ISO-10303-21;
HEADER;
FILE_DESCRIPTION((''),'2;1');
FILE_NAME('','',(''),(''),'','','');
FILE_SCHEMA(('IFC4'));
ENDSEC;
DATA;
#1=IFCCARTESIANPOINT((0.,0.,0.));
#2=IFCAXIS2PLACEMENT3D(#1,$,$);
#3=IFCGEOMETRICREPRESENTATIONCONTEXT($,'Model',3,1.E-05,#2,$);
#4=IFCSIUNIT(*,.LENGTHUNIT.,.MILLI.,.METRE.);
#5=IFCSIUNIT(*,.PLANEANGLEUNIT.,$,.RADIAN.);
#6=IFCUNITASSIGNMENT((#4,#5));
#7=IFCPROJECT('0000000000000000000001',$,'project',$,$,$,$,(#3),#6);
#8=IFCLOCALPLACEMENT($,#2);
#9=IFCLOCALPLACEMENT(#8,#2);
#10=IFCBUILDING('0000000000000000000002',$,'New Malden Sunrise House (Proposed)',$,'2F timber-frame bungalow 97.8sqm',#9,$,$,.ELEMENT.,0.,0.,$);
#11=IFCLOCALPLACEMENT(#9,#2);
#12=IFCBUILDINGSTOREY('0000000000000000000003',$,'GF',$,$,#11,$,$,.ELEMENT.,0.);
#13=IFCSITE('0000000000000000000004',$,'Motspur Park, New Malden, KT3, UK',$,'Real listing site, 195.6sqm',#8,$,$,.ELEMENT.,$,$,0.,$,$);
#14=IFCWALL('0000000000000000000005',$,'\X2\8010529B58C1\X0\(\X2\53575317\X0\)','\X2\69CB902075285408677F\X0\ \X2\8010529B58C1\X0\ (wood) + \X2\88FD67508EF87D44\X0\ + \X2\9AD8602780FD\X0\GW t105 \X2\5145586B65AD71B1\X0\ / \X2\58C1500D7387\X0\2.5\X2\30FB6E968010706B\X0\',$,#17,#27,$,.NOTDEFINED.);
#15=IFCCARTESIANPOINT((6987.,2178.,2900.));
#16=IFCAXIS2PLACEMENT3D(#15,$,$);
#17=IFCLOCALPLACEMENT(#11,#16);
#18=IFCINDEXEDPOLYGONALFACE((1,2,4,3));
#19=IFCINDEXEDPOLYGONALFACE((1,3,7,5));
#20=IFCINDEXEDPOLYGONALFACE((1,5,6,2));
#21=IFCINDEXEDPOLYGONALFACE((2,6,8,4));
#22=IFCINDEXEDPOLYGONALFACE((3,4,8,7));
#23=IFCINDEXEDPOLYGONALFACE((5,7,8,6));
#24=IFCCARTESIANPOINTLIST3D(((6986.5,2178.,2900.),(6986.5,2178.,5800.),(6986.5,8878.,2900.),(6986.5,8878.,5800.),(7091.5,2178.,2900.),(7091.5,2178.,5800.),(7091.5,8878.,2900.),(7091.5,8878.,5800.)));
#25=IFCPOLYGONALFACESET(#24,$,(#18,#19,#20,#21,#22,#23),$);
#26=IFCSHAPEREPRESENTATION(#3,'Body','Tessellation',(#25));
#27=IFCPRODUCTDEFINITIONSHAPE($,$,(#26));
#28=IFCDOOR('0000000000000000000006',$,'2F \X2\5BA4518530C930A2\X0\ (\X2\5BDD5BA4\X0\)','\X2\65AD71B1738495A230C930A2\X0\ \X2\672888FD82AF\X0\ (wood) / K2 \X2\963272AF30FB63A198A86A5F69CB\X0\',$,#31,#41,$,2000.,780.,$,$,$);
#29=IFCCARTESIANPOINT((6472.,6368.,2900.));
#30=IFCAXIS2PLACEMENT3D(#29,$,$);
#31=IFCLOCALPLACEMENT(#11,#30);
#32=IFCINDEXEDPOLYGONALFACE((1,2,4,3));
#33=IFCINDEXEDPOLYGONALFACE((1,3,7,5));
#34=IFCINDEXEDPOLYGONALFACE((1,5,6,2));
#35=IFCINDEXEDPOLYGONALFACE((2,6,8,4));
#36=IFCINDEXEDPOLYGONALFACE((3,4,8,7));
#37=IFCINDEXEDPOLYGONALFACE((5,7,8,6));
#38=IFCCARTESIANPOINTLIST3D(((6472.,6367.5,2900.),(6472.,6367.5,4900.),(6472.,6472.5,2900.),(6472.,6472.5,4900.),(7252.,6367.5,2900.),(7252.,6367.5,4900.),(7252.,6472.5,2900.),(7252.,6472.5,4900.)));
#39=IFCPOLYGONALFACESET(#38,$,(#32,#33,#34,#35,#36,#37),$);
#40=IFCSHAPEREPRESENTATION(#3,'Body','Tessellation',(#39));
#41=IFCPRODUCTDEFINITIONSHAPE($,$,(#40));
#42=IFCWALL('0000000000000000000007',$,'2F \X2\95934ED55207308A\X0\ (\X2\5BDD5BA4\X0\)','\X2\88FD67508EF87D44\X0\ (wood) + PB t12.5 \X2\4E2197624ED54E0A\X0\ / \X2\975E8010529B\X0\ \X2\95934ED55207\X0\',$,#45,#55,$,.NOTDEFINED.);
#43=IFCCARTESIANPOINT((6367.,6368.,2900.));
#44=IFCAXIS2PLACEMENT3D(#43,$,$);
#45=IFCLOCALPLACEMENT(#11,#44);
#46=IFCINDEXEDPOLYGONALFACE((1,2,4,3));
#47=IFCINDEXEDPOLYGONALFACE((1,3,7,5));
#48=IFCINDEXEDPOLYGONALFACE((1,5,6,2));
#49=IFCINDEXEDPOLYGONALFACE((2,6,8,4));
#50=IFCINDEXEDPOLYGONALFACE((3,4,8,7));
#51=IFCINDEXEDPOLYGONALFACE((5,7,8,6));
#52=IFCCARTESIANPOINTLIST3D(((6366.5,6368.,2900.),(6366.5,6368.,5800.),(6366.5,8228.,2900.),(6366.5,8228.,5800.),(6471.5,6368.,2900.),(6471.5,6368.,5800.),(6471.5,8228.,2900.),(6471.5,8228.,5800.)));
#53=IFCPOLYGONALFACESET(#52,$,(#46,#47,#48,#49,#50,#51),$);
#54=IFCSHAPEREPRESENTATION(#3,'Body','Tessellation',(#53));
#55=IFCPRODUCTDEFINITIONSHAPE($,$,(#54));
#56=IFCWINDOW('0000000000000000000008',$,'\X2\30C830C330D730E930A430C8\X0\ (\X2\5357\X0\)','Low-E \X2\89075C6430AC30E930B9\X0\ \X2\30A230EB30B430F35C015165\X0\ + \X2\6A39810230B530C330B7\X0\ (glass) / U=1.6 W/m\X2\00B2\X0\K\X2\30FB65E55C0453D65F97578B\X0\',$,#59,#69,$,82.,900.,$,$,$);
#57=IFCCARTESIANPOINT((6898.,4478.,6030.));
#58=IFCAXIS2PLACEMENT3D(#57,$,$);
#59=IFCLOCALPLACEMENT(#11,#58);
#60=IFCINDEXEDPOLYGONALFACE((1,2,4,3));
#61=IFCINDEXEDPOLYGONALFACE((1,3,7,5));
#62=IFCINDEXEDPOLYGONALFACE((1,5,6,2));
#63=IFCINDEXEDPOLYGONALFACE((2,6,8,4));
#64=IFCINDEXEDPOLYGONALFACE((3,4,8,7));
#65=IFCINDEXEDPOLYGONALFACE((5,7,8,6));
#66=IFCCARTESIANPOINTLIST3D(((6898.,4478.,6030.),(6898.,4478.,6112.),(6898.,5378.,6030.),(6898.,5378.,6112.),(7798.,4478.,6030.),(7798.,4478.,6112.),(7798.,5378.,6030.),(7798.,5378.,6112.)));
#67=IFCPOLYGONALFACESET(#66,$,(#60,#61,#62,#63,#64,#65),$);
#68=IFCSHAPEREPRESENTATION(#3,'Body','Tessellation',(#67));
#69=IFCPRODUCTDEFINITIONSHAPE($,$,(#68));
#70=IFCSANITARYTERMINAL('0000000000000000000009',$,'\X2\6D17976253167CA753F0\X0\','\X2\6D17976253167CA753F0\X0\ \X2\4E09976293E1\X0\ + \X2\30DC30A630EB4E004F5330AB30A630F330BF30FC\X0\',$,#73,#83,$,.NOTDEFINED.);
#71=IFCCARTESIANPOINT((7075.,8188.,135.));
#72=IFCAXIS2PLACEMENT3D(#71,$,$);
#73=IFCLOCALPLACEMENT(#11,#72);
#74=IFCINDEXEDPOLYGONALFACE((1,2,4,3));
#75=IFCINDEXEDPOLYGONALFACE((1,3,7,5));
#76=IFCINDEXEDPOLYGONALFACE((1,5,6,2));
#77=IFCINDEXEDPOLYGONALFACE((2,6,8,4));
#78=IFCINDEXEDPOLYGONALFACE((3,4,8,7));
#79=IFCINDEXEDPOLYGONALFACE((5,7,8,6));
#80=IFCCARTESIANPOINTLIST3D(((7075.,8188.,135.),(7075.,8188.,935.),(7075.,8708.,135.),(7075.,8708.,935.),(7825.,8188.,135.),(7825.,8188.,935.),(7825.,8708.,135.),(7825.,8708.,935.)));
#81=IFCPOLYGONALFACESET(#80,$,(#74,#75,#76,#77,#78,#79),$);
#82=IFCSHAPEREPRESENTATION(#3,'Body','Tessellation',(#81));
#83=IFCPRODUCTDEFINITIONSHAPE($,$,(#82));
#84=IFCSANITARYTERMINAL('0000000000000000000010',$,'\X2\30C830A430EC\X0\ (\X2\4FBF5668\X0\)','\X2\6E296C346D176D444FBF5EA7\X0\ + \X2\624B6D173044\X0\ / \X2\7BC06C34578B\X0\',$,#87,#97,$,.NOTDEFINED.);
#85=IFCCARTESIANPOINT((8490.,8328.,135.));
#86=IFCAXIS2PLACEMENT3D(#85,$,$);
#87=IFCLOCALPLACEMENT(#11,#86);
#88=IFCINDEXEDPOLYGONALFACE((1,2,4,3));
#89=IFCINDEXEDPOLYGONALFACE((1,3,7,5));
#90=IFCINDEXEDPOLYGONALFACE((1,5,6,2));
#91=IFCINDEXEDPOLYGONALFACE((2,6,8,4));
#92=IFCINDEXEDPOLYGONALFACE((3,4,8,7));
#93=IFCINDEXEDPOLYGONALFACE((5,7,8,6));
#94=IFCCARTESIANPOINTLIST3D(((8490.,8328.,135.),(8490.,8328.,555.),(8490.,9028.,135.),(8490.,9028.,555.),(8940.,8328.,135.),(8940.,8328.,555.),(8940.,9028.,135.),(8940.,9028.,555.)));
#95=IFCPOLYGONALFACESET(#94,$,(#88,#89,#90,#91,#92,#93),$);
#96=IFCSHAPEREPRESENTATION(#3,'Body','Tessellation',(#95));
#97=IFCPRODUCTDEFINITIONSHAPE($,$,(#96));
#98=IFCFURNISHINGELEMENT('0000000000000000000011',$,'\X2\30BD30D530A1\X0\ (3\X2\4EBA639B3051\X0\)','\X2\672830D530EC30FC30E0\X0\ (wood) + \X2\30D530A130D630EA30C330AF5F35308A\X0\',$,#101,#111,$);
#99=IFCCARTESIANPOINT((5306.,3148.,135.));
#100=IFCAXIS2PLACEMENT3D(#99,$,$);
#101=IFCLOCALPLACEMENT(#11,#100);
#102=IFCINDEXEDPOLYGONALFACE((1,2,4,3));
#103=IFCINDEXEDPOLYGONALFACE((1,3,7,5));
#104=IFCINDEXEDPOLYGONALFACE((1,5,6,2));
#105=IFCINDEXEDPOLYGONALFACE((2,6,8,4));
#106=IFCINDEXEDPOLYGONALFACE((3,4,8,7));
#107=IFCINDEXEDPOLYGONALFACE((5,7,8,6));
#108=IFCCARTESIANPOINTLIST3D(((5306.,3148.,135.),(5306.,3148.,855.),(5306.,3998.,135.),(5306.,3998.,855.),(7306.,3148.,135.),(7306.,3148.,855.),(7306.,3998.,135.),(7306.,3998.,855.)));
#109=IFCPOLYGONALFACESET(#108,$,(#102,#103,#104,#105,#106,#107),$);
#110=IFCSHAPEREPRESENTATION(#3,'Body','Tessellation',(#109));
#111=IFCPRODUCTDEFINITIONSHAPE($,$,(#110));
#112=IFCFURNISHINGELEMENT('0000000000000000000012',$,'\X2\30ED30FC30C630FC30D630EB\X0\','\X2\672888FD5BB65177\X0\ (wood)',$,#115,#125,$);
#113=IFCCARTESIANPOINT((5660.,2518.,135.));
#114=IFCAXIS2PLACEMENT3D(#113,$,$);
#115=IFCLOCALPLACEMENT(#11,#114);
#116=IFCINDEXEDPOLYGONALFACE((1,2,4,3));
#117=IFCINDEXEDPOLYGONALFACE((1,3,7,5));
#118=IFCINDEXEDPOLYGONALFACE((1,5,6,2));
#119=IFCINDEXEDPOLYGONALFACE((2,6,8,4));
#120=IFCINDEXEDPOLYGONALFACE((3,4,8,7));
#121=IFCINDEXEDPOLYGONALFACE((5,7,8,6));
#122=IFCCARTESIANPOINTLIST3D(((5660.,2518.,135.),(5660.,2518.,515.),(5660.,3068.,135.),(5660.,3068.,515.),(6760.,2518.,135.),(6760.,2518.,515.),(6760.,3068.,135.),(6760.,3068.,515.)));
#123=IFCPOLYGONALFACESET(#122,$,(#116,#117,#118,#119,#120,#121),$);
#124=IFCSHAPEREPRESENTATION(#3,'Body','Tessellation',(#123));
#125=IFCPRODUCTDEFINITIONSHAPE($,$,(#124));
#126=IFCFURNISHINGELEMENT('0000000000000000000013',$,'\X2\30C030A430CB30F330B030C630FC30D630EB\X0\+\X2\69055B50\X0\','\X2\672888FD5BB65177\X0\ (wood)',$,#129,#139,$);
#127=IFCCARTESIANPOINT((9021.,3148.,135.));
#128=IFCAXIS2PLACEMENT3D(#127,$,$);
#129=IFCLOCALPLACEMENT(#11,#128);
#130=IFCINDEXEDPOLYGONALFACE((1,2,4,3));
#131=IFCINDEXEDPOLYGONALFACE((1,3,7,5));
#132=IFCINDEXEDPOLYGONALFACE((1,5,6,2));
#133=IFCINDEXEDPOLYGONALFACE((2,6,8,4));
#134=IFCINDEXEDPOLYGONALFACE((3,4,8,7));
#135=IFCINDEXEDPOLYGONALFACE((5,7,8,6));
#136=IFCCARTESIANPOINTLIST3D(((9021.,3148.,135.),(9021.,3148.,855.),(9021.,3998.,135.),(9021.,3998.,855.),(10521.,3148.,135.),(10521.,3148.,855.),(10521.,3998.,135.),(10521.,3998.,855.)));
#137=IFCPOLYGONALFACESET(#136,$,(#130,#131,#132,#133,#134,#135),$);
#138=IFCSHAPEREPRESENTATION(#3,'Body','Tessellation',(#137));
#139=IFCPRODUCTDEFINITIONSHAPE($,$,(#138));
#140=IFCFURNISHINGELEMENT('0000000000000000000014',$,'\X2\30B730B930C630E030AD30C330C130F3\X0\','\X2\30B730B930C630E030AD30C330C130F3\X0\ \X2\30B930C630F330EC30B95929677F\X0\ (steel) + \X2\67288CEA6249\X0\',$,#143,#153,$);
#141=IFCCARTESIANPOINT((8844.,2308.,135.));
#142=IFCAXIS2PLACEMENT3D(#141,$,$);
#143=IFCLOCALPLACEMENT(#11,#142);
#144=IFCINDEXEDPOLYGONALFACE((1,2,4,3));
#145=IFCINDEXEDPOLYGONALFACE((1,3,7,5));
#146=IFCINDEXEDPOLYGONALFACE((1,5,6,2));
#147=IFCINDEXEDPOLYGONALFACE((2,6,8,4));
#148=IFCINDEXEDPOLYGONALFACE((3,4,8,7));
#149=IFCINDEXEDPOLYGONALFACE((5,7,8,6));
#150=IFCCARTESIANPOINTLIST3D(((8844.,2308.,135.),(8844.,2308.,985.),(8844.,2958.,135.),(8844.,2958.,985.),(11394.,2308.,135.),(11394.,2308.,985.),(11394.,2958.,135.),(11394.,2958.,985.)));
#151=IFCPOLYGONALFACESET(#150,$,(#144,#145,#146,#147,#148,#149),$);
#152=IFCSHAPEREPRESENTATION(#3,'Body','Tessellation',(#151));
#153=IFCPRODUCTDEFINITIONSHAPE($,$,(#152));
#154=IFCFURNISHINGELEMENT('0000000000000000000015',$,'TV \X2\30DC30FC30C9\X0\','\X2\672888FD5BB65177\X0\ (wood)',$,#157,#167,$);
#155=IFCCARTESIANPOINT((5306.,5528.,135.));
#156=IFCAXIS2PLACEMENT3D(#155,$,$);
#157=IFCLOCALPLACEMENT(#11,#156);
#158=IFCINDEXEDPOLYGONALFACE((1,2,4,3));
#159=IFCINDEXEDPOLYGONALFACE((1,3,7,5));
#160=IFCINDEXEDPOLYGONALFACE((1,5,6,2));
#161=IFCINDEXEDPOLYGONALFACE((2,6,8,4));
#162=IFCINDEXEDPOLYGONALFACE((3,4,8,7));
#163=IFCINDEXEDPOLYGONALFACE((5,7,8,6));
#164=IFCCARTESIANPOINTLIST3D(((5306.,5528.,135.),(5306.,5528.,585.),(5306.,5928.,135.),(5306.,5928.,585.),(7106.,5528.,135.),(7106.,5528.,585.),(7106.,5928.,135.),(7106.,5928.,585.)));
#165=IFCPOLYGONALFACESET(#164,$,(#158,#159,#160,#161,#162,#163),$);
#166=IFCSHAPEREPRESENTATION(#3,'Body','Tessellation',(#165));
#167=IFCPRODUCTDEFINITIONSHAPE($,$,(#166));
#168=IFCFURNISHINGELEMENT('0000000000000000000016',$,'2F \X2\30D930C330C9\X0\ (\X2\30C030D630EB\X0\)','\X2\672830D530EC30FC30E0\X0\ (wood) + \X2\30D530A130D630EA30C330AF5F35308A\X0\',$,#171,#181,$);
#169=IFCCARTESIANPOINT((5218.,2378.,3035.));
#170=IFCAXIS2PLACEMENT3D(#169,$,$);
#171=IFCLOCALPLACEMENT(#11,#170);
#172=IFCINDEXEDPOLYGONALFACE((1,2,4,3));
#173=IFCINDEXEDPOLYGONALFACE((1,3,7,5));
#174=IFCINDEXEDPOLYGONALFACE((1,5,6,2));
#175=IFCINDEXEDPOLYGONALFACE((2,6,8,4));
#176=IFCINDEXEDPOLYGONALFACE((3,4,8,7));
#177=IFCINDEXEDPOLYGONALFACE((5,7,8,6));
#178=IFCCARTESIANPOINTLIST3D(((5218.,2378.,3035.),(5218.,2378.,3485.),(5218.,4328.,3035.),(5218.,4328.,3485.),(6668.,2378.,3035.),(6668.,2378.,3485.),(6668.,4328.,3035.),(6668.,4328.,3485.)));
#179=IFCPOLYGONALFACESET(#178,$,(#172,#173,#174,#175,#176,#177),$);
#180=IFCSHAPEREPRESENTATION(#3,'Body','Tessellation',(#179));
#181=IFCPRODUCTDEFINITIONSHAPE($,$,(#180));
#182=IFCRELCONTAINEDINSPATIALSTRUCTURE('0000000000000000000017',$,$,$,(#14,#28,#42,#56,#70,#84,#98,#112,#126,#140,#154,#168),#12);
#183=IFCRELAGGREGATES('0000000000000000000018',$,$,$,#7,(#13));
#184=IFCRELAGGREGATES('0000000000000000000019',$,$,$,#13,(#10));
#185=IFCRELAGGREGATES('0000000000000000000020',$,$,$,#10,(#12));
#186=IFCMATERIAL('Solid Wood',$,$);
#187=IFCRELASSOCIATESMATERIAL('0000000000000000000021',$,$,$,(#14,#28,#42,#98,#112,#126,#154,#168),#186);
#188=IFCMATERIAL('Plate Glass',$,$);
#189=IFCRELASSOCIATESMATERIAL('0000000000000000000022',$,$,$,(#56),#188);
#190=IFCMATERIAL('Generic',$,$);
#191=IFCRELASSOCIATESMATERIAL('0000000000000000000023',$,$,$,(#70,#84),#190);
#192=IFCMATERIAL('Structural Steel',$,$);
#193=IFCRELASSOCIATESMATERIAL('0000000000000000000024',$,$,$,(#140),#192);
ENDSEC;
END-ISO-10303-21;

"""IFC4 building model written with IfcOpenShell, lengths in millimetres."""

from ifc_helpers import new_model, si_unit, frame, frame_2d, origin, place, context, project, spatial, rectangle, extrude, material, element, fill, save


model = new_model("IFC4")

# Units and contexts
model_context = context("Model", 3, precision=1e-05, world=origin())
ifc_project = project(units=[si_unit("LENGTHUNIT", "METRE", prefix="MILLI"), si_unit("PLANEANGLEUNIT", "RADIAN")], contexts=[model_context])

# Site, building, storey
site_placement = place(None, origin())
site = spatial("IfcSite", under=ifc_project, at=site_placement, Name="Motspur Park, New Malden, KT3, UK", ObjectType="Real listing site, 195.6sqm", CompositionType="ELEMENT", RefElevation=0.0)
building_placement = place(site_placement, origin())
building = spatial("IfcBuilding", under=site, at=building_placement, Name="New Malden Sunrise House (Proposed)", ObjectType="2F timber-frame bungalow 97.8sqm", CompositionType="ELEMENT", ElevationOfRefHeight=0.0, ElevationOfTerrain=0.0)
storey_placement = place(building_placement, origin())
storey = spatial("IfcBuildingStorey", under=building, at=storey_placement, Name="GF", CompositionType="ELEMENT", Elevation=0.0)

# Shared definitions
ifc_material_1 = material(Name="Solid Wood")

# Wall, opening, door
wall_1_placement = place(storey_placement, frame((6987.0, 2178.0, 2900.0)))
wall_1 = element("IfcWall", 1, at=wall_1_placement, inside=storey, material=ifc_material_1, Name="耐力壁(南北)", Description="構造用合板 耐力壁 (wood) + 製材軸組 + 高性能GW t105 充填断熱 / 壁倍率2.5・準耐火", PredefinedType="NOTDEFINED", context=model_context, shape_type="SweptSolid", body=[
    extrude(rectangle(XDim=105.0, YDim=6700.0, at=frame_2d((52.0, 3350.0))), frame((6987.0, 2178.0, 2900.0)), (0.0, 0.0, 1.0), 2900.0),
])
opening_1_placement = place(storey_placement, frame((6472.0, 6368.0, 2900.0)))
opening_1 = element("IfcOpeningElement", 2, at=opening_1_placement, cuts=wall_1, PredefinedType="NOTDEFINED", context=model_context, shape_type="SweptSolid", body=[
    extrude(rectangle(XDim=780.0, YDim=105.0, at=frame_2d((390.0, 52.0))), frame((6472.0, 6368.0, 2900.0)), (0.0, 0.0, 1.0), 2000.0),
])
door_1_placement = place(storey_placement, frame((6472.0, 6368.0, 2900.0)))
door_1 = element("IfcDoor", 3, at=door_1_placement, inside=storey, material=ifc_material_1, Name="2F 室内ドア (寝室)", Description="断熱玄関ドア 木製芯 (wood) / K2 防犯・採風機構", OverallHeight=2000.0, OverallWidth=780.0, context=model_context, shape_type="SweptSolid", body=[
    extrude(rectangle(XDim=780.0, YDim=105.0, at=frame_2d((390.0, 52.0))), frame((6472.0, 6368.0, 2900.0)), (0.0, 0.0, 1.0), 2000.0),
])
fill(opening_1, door_1)

# Wall
wall_2_placement = place(storey_placement, frame((6367.0, 6368.0, 2900.0)))
element("IfcWall", 4, at=wall_2_placement, inside=storey, material=ifc_material_1, Name="2F 間仕切り (寝室)", Description="製材軸組 (wood) + PB t12.5 両面仕上 / 非耐力 間仕切", PredefinedType="NOTDEFINED", context=model_context, shape_type="SweptSolid", body=[
    extrude(rectangle(XDim=105.0, YDim=1860.0, at=frame_2d((52.0, 930.0))), frame((6367.0, 6368.0, 2900.0)), (0.0, 0.0, 1.0), 2900.0),
])

# Window
ifc_material_2 = material(Name="Plate Glass")
window_placement = place(storey_placement, frame((6898.0, 4478.0, 6030.0)))
element("IfcWindow", 5, at=window_placement, inside=storey, material=ifc_material_2, Name="トップライト (南)", Description="Low-E 複層ガラス アルゴン封入 + 樹脂サッシ (glass) / U=1.6 W/m²K・日射取得型", OverallHeight=82.0, OverallWidth=900.0, context=model_context, shape_type="SweptSolid", body=[
    extrude(rectangle(XDim=900.0, YDim=900.0, at=frame_2d((450.0, 450.0))), frame((6898.0, 4478.0, 6030.0)), (0.0, 0.0, 1.0), 82.0),
])

# Sanitary terminals
ifc_material_3 = material(Name="Generic")
sanitary_terminal_1_placement = place(storey_placement, frame((7075.0, 8188.0, 135.0)))
element("IfcSanitaryTerminal", 6, at=sanitary_terminal_1_placement, inside=storey, material=ifc_material_3, Name="洗面化粧台", Description="洗面化粧台 三面鏡 + ボウル一体カウンター", PredefinedType="NOTDEFINED", context=model_context, shape_type="SweptSolid", body=[
    extrude(rectangle(XDim=750.0, YDim=520.0, at=frame_2d((375.0, 260.0))), frame((7075.0, 8188.0, 135.0)), (0.0, 0.0, 1.0), 800.0),
])
sanitary_terminal_2_placement = place(storey_placement, frame((8490.0, 8328.0, 135.0)))
element("IfcSanitaryTerminal", 7, at=sanitary_terminal_2_placement, inside=storey, material=ifc_material_3, Name="トイレ (便器)", Description="温水洗浄便座 + 手洗い / 節水型", PredefinedType="NOTDEFINED", context=model_context, shape_type="SweptSolid", body=[
    extrude(rectangle(XDim=450.0, YDim=700.0, at=frame_2d((225.0, 350.0))), frame((8490.0, 8328.0, 135.0)), (0.0, 0.0, 1.0), 420.0),
])

# Furnishing elements
furnishing_1_placement = place(storey_placement, frame((5306.0, 3148.0, 135.0)))
element("IfcFurnishingElement", 8, at=furnishing_1_placement, inside=storey, material=ifc_material_1, Name="ソファ (3人掛け)", Description="木フレーム (wood) + ファブリック張り", context=model_context, shape_type="SweptSolid", body=[
    extrude(rectangle(XDim=2000.0, YDim=850.0, at=frame_2d((1000.0, 425.0))), frame((5306.0, 3148.0, 135.0)), (0.0, 0.0, 1.0), 720.0),
])
furnishing_2_placement = place(storey_placement, frame((5660.0, 2518.0, 135.0)))
element("IfcFurnishingElement", 9, at=furnishing_2_placement, inside=storey, material=ifc_material_1, Name="ローテーブル", Description="木製家具 (wood)", context=model_context, shape_type="SweptSolid", body=[
    extrude(rectangle(XDim=1100.0, YDim=550.0, at=frame_2d((550.0, 275.0))), frame((5660.0, 2518.0, 135.0)), (0.0, 0.0, 1.0), 380.0),
])
furnishing_3_placement = place(storey_placement, frame((9021.0, 3148.0, 135.0)))
element("IfcFurnishingElement", 10, at=furnishing_3_placement, inside=storey, material=ifc_material_1, Name="ダイニングテーブル+椅子", Description="木製家具 (wood)", context=model_context, shape_type="SweptSolid", body=[
    extrude(rectangle(XDim=1500.0, YDim=850.0, at=frame_2d((750.0, 425.0))), frame((9021.0, 3148.0, 135.0)), (0.0, 0.0, 1.0), 720.0),
])
ifc_material_4 = material(Name="Structural Steel")
furnishing_4_placement = place(storey_placement, frame((8844.0, 2308.0, 135.0)))
element("IfcFurnishingElement", 11, at=furnishing_4_placement, inside=storey, material=ifc_material_4, Name="システムキッチン", Description="システムキッチン ステンレス天板 (steel) + 木質扉", context=model_context, shape_type="SweptSolid", body=[
    extrude(rectangle(XDim=2550.0, YDim=650.0, at=frame_2d((1275.0, 325.0))), frame((8844.0, 2308.0, 135.0)), (0.0, 0.0, 1.0), 850.0),
])
furnishing_5_placement = place(storey_placement, frame((5306.0, 5528.0, 135.0)))
element("IfcFurnishingElement", 12, at=furnishing_5_placement, inside=storey, material=ifc_material_1, Name="TV ボード", Description="木製家具 (wood)", context=model_context, shape_type="SweptSolid", body=[
    extrude(rectangle(XDim=1800.0, YDim=400.0, at=frame_2d((900.0, 200.0))), frame((5306.0, 5528.0, 135.0)), (0.0, 0.0, 1.0), 450.0),
])
furnishing_6_placement = place(storey_placement, frame((5218.0, 2378.0, 3035.0)))
element("IfcFurnishingElement", 13, at=furnishing_6_placement, inside=storey, material=ifc_material_1, Name="2F ベッド (ダブル)", Description="木フレーム (wood) + ファブリック張り", context=model_context, shape_type="SweptSolid", body=[
    extrude(rectangle(XDim=1450.0, YDim=1950.0, at=frame_2d((725.0, 975.0))), frame((5218.0, 2378.0, 3035.0)), (0.0, 0.0, 1.0), 450.0),
])

save(model, "model.ifc")
